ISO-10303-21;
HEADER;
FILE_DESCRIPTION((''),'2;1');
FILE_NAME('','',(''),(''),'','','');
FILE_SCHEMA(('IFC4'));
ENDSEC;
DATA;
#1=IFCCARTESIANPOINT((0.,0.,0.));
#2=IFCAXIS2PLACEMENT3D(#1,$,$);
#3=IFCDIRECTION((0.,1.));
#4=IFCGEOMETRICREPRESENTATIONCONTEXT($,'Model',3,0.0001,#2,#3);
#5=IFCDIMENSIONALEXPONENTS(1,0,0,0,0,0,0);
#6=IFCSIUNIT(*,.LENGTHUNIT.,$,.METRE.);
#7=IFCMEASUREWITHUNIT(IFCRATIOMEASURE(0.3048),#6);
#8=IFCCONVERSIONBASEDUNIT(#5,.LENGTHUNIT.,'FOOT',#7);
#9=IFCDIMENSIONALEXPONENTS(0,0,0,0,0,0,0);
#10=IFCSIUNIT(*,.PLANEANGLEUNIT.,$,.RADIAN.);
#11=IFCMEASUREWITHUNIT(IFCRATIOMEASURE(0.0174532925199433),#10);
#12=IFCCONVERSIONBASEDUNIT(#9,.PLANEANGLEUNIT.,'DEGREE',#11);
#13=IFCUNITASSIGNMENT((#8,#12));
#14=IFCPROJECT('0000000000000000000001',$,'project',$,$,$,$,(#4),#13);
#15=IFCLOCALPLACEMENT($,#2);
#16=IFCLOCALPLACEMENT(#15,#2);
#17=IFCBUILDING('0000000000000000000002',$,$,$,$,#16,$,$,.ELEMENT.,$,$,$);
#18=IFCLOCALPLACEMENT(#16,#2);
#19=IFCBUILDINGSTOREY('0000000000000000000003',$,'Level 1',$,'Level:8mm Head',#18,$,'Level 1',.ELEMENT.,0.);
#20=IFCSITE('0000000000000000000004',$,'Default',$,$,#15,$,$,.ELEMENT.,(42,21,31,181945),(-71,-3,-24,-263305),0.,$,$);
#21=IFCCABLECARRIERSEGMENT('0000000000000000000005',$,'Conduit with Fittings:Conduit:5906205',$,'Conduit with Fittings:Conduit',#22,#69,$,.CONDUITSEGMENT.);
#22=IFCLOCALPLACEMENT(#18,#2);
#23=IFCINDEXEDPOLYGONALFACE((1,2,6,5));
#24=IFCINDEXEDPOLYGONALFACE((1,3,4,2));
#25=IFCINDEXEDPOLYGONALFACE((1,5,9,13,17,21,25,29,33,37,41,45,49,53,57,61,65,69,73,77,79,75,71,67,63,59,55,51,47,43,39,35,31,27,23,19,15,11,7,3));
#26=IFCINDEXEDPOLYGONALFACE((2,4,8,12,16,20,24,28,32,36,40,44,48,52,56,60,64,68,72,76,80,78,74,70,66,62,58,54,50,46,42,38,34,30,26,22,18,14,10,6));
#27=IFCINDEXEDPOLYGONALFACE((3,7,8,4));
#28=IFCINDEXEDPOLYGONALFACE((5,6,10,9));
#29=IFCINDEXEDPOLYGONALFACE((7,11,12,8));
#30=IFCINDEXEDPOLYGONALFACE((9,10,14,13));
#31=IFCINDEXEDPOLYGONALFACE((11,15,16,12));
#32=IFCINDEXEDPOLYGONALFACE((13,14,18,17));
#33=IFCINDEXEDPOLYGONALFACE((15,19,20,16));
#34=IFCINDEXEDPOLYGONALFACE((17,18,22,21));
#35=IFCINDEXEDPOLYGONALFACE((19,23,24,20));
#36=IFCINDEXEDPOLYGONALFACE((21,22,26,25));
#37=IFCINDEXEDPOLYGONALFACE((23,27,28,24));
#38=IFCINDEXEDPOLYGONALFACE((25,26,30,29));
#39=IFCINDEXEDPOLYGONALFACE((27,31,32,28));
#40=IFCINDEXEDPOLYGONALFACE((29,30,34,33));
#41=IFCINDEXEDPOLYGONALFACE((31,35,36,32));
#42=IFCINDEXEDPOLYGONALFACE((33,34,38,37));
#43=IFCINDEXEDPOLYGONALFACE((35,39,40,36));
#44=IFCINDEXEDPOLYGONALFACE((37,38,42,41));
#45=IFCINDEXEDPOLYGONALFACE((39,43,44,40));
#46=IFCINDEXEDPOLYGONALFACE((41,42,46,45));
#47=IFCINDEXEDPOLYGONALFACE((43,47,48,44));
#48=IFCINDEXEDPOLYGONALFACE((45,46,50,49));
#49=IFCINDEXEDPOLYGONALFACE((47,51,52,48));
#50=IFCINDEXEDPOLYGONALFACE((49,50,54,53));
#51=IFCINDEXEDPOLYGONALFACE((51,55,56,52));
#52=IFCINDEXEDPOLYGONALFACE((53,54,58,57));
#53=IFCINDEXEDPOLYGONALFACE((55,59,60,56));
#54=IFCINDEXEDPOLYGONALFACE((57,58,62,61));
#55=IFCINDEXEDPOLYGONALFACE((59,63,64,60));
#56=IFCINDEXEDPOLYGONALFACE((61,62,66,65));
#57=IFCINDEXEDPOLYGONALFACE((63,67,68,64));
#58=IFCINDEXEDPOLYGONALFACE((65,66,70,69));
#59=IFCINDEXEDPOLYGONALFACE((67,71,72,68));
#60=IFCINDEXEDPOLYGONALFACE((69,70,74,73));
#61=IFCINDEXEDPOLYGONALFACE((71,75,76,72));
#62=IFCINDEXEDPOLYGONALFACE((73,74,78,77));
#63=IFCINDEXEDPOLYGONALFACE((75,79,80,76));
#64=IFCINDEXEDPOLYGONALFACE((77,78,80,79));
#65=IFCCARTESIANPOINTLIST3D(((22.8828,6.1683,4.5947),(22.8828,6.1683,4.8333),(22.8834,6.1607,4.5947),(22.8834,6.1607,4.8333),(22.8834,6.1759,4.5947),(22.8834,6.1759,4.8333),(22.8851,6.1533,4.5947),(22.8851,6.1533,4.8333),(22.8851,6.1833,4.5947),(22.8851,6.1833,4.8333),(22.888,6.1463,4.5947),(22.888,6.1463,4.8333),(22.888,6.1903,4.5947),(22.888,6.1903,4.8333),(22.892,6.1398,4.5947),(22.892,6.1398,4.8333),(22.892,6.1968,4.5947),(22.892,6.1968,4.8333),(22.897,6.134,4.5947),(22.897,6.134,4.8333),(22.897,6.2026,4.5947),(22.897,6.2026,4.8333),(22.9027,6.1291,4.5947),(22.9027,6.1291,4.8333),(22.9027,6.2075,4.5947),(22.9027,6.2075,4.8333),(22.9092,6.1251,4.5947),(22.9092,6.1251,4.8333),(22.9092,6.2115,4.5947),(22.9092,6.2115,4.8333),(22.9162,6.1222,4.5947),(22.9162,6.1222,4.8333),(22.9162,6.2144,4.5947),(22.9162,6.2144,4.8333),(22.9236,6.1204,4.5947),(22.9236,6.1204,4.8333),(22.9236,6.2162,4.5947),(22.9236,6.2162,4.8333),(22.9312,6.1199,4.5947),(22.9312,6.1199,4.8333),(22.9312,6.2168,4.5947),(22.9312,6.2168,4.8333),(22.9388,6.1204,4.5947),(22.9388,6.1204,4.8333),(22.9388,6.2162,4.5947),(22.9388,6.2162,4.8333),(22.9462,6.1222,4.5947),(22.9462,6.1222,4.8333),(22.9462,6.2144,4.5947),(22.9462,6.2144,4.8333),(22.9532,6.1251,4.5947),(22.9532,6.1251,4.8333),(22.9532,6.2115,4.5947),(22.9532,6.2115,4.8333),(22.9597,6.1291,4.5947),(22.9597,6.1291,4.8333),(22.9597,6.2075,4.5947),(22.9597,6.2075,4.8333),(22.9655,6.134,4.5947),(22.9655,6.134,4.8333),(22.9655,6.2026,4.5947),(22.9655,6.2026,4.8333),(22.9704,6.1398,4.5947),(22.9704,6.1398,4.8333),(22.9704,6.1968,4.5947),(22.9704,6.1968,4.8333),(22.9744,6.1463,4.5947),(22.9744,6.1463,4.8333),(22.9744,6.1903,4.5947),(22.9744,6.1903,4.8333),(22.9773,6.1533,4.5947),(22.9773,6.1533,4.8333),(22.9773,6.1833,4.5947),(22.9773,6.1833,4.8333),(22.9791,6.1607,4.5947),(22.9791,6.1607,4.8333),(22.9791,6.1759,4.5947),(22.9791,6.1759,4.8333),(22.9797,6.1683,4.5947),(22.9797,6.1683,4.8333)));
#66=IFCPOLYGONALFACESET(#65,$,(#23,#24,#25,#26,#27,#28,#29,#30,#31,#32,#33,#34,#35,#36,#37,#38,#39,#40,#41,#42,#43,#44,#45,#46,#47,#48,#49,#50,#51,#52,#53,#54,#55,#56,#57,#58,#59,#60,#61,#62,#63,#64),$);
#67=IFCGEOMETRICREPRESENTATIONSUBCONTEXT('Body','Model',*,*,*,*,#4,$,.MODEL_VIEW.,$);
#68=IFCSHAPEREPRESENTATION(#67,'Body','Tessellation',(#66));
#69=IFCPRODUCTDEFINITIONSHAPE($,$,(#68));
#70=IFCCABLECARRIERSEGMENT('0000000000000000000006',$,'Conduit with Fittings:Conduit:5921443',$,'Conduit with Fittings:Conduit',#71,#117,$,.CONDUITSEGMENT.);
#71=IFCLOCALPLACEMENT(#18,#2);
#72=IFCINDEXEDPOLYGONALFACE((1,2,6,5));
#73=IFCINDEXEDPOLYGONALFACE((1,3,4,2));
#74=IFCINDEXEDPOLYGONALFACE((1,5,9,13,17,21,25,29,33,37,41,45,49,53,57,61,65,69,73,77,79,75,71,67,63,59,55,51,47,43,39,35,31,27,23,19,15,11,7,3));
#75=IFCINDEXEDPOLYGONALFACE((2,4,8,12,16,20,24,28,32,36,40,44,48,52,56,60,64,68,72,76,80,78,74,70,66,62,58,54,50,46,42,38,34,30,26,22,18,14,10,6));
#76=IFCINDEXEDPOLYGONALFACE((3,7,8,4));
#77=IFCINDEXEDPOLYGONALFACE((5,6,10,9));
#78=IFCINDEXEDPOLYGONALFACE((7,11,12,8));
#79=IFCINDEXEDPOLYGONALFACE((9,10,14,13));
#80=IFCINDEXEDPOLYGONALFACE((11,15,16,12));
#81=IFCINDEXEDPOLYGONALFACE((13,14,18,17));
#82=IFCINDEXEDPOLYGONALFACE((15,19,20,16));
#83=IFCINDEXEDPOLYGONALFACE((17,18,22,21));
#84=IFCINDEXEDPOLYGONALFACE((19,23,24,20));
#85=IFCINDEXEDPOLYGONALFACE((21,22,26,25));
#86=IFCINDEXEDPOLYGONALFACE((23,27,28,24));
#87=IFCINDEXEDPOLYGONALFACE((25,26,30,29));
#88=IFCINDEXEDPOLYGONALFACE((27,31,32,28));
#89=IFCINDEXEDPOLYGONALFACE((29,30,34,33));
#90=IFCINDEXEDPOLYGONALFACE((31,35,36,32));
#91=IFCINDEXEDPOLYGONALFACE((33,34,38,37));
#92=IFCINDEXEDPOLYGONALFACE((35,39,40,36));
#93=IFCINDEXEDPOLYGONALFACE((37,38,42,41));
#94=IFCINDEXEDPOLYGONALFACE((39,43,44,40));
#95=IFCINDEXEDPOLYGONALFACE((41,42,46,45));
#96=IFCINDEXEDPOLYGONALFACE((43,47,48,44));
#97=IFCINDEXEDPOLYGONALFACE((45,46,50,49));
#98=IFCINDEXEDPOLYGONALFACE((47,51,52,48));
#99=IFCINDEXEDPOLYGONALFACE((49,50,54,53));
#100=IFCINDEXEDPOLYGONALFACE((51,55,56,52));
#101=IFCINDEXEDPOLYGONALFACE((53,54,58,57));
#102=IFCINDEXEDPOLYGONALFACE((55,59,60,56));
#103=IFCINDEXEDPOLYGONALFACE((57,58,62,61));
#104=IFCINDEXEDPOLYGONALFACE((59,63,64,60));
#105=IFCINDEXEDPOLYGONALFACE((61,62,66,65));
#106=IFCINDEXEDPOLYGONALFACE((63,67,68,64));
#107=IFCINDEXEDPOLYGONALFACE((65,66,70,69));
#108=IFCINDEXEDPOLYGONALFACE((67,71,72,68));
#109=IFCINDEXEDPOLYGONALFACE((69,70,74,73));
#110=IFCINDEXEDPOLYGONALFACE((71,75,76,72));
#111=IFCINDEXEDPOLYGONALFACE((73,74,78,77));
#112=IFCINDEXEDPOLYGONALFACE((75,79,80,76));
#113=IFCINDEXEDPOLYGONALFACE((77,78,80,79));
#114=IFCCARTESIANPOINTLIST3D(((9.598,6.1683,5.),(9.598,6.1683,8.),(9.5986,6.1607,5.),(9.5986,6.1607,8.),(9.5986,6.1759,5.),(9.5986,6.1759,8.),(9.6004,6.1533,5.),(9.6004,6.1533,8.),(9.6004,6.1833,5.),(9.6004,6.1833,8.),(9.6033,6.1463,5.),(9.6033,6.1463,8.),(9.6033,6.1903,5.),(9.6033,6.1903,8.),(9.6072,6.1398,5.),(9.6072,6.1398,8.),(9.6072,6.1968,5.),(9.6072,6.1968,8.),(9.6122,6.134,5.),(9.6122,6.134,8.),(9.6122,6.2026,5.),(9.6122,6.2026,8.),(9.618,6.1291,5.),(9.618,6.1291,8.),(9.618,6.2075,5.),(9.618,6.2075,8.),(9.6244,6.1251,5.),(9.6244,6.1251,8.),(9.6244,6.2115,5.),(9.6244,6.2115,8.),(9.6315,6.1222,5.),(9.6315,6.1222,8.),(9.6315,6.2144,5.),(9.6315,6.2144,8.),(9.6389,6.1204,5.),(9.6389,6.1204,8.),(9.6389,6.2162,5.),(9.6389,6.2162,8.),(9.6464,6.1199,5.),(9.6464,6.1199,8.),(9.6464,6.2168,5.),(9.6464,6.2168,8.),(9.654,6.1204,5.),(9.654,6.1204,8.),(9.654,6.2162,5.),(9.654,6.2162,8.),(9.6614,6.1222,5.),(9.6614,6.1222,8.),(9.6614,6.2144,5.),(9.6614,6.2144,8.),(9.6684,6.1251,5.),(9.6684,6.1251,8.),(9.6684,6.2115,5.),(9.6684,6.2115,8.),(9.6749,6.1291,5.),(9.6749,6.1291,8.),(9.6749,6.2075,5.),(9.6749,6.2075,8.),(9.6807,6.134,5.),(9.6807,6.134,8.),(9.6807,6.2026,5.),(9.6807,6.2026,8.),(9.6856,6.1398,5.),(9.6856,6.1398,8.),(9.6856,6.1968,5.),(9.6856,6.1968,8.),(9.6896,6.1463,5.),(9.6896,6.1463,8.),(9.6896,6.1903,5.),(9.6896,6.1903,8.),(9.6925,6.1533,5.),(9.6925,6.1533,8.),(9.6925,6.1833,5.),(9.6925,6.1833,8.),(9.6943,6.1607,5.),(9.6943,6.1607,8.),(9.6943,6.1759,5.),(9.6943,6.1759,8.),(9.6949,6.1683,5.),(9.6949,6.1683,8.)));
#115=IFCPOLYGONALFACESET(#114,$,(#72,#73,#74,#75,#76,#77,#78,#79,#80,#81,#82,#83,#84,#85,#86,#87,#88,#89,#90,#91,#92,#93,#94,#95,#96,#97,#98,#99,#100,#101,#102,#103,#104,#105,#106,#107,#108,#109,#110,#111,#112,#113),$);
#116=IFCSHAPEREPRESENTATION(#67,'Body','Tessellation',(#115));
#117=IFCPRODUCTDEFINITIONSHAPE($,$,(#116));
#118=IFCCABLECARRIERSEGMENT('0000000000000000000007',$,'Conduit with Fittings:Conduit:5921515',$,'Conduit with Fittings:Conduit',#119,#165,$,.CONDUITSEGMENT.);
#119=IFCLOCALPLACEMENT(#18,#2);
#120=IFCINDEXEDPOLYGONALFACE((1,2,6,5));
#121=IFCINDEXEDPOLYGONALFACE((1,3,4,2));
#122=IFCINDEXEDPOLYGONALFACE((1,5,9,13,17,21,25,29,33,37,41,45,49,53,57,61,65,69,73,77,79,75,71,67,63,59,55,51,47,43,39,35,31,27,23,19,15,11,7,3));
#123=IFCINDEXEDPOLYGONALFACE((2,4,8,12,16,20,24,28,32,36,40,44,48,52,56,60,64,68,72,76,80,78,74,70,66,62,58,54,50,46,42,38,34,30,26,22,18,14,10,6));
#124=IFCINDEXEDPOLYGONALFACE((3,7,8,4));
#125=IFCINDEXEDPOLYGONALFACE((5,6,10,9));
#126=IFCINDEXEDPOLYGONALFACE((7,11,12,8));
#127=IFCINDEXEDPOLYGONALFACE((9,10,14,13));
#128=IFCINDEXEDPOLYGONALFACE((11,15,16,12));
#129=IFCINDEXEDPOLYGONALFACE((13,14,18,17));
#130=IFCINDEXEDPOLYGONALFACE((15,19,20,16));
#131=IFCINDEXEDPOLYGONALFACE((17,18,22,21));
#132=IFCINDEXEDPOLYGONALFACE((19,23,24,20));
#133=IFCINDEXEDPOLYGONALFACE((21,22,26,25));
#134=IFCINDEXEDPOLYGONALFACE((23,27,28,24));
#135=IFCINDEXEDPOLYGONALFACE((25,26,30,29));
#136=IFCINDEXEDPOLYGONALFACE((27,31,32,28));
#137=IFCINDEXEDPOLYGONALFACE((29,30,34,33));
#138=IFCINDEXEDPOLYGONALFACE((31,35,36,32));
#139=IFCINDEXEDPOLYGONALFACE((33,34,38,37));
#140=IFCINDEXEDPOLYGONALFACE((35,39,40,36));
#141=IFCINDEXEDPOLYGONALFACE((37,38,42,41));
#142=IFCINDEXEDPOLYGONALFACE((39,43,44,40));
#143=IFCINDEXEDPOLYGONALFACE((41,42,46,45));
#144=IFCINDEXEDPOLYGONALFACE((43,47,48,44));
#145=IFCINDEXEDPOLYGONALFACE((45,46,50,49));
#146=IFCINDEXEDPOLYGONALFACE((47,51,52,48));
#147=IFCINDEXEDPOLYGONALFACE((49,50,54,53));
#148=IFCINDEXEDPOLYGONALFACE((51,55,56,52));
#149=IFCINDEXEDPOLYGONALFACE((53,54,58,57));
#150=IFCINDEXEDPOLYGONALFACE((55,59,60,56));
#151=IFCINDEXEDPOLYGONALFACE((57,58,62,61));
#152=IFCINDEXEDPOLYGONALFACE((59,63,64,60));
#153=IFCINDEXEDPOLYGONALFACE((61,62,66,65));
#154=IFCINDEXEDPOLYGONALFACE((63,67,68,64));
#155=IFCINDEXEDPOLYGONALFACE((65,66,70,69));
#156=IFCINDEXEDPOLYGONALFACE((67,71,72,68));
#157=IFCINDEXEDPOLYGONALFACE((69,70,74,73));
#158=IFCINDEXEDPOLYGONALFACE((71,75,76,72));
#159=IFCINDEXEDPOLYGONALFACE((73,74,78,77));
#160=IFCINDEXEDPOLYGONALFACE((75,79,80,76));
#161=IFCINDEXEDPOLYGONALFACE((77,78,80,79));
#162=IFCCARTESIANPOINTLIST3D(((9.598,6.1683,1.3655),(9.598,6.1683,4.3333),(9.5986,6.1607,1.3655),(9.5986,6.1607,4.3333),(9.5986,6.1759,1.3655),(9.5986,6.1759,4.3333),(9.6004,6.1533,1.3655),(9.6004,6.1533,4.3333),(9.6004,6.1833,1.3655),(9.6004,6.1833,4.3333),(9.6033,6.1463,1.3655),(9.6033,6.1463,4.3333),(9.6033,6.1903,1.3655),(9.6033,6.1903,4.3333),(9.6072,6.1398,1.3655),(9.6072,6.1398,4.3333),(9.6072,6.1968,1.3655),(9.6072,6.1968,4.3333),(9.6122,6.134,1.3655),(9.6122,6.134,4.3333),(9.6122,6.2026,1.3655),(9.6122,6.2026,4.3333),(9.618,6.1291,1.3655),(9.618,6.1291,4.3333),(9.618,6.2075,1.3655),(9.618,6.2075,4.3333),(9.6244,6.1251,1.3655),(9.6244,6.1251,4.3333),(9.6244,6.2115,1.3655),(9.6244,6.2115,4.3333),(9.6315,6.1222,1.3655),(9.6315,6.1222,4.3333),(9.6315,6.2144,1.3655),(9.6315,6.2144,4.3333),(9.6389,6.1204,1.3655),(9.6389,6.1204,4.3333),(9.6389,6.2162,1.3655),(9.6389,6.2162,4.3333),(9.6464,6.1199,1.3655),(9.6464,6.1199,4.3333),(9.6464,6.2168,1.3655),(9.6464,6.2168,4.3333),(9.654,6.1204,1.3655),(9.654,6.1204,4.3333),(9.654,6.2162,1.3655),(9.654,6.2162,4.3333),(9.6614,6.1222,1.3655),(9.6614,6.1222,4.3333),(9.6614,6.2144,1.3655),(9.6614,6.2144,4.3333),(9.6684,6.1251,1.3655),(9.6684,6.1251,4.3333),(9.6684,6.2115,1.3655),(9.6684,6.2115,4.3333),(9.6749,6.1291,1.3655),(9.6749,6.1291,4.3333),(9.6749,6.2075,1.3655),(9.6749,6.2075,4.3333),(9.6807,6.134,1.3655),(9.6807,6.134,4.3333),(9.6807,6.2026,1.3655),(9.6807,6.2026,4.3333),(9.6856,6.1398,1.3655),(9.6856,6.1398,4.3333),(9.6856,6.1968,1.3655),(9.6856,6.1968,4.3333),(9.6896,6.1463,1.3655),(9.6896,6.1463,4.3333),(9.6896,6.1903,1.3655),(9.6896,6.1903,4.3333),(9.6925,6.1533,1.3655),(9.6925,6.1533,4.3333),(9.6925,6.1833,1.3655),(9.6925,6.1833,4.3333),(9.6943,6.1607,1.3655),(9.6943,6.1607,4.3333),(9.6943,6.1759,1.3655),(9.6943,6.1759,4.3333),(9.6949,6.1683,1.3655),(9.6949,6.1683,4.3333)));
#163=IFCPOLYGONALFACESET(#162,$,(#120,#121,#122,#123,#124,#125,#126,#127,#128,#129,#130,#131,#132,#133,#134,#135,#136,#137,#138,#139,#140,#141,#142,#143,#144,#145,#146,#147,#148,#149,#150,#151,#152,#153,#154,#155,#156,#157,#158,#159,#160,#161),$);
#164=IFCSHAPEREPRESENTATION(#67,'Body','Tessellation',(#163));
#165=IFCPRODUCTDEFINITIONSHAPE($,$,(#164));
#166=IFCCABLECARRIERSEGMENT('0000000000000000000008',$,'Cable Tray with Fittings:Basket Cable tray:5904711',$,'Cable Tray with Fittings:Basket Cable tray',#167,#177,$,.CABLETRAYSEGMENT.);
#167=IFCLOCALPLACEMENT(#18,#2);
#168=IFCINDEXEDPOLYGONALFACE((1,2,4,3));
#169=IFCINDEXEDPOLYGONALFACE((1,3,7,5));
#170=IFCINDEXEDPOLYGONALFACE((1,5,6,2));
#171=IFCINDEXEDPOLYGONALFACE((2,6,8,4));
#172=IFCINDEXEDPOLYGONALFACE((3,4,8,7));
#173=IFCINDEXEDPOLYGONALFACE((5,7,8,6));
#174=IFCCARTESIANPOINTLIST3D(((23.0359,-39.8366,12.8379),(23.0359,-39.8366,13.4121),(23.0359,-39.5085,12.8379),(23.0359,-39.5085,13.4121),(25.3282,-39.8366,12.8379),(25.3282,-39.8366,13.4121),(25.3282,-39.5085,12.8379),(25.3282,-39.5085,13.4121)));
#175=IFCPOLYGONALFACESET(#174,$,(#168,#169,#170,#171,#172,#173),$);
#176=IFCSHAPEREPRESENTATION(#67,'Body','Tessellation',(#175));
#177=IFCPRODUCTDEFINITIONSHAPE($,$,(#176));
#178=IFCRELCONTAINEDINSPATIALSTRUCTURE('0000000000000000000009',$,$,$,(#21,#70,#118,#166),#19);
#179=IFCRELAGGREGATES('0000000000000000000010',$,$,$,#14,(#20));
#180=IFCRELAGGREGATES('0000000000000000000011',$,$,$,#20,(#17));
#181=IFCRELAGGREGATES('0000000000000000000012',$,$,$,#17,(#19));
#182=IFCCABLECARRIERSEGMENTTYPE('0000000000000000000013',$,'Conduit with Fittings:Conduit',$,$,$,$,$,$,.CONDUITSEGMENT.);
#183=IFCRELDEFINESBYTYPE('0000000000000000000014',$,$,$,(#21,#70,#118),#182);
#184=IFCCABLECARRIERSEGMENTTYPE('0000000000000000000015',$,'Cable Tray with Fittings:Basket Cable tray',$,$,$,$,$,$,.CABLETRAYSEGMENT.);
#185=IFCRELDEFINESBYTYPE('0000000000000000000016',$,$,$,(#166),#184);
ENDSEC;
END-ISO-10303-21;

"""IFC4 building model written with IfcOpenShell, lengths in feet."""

from ifc_helpers import new_model, entity, si_unit, converted_unit, direction, frame, origin, place, context, subcontext, project, spatial, indexed_curve, outline, extrude, type_object, element, save


model = new_model("IFC4")

# Units and contexts
model_context = context("Model", 3, precision=0.0001, world=origin(), true_north=direction((0.0, 1.0)))
body_context = subcontext(model_context, "Body", "Model", "MODEL_VIEW")
ifc_project = project(units=[converted_unit("LENGTHUNIT", "FOOT", entity("IfcRatioMeasure", 0.3048), si_unit("LENGTHUNIT", "METRE"), dimensions=[1, 0, 0, 0, 0, 0, 0]), converted_unit("PLANEANGLEUNIT", "DEGREE", entity("IfcRatioMeasure", 0.0174532925199433), si_unit("PLANEANGLEUNIT", "RADIAN"), dimensions=[0, 0, 0, 0, 0, 0, 0])], contexts=[model_context])

# Site, building, storey
site_placement = place(None, origin())
site = spatial("IfcSite", under=ifc_project, at=site_placement, Name="Default", CompositionType="ELEMENT", RefLatitude=(42, 21, 31, 181945), RefLongitude=(-71, -3, -24, -263305), RefElevation=0.0)
building_placement = place(site_placement, origin())
building = spatial("IfcBuilding", under=site, at=building_placement, CompositionType="ELEMENT")
storey_placement = place(building_placement, origin())
storey = spatial("IfcBuildingStorey", under=building, at=storey_placement, Name="Level 1", ObjectType="Level:8mm Head", LongName="Level 1", CompositionType="ELEMENT", Elevation=0.0)

# Cable carrier segments
cable_carrier_segment_type_1 = type_object("IfcCableCarrierSegmentType", Name="Conduit with Fittings:Conduit", PredefinedType="CONDUITSEGMENT")
cable_carrier_segment_1_placement = place(storey_placement, origin())
element("IfcCableCarrierSegment", 1, at=cable_carrier_segment_1_placement, inside=storey, type_object=cable_carrier_segment_type_1, Name="Conduit with Fittings:Conduit:5906205", ObjectType="Conduit with Fittings:Conduit", PredefinedType="CONDUITSEGMENT", context=body_context, shape_type="SweptSolid", body=[
    extrude(outline(indexed_curve([(0.0485, 0.0), (0.0479, 0.0076), (0.0461, 0.015), (0.0432, 0.022), (0.0392, 0.0285), (0.0343, 0.0343), (0.0285, 0.0392), (0.022, 0.0432), (0.015, 0.0461), (0.0076, 0.0479), (0.0, 0.0485), (-0.0076, 0.0479), (-0.015, 0.0461), (-0.022, 0.0432), (-0.0285, 0.0392), (-0.0343, 0.0343), (-0.0392, 0.0285), (-0.0432, 0.022), (-0.0461, 0.015), (-0.0479, 0.0076), (-0.0485, 0.0), (-0.0479, -0.0076), (-0.0461, -0.015), (-0.0432, -0.022), (-0.0392, -0.0285), (-0.0343, -0.0343), (-0.0285, -0.0392), (-0.022, -0.0432), (-0.015, -0.0461), (-0.0076, -0.0479), (0.0, -0.0485), (0.0076, -0.0479), (0.015, -0.0461), (0.022, -0.0432), (0.0285, -0.0392), (0.0343, -0.0343), (0.0392, -0.0285), (0.0432, -0.022), (0.0461, -0.015), (0.0479, -0.0076), (0.0485, 0.0)], self_intersect=False)), frame((22.9312, 6.1683, 4.5947), z_axis=(0.0, 0.0, 1.0), x_axis=(-1.0, 0.0, 0.0)), (0.0, 0.0, 1.0), 0.2387),
])
cable_carrier_segment_2_placement = place(storey_placement, origin())
element("IfcCableCarrierSegment", 2, at=cable_carrier_segment_2_placement, inside=storey, type_object=cable_carrier_segment_type_1, Name="Conduit with Fittings:Conduit:5921443", ObjectType="Conduit with Fittings:Conduit", PredefinedType="CONDUITSEGMENT", context=body_context, shape_type="SweptSolid", body=[
    extrude(outline(indexed_curve([(0.0485, 0.0), (0.0479, 0.0076), (0.0461, 0.015), (0.0432, 0.022), (0.0392, 0.0285), (0.0343, 0.0343), (0.0285, 0.0392), (0.022, 0.0432), (0.015, 0.0461), (0.0076, 0.0479), (0.0, 0.0485), (-0.0076, 0.0479), (-0.015, 0.0461), (-0.022, 0.0432), (-0.0285, 0.0392), (-0.0343, 0.0343), (-0.0392, 0.0285), (-0.0432, 0.022), (-0.0461, 0.015), (-0.0479, 0.0076), (-0.0485, 0.0), (-0.0479, -0.0076), (-0.0461, -0.015), (-0.0432, -0.022), (-0.0392, -0.0285), (-0.0343, -0.0343), (-0.0285, -0.0392), (-0.022, -0.0432), (-0.015, -0.0461), (-0.0076, -0.0479), (0.0, -0.0485), (0.0076, -0.0479), (0.015, -0.0461), (0.022, -0.0432), (0.0285, -0.0392), (0.0343, -0.0343), (0.0392, -0.0285), (0.0432, -0.022), (0.0461, -0.015), (0.0479, -0.0076), (0.0485, 0.0)], self_intersect=False)), frame((9.6464, 6.1683, 5.0)), (0.0, 0.0, 1.0), 3.0),
])
cable_carrier_segment_3_placement = place(storey_placement, origin())
element("IfcCableCarrierSegment", 3, at=cable_carrier_segment_3_placement, inside=storey, type_object=cable_carrier_segment_type_1, Name="Conduit with Fittings:Conduit:5921515", ObjectType="Conduit with Fittings:Conduit", PredefinedType="CONDUITSEGMENT", context=body_context, shape_type="SweptSolid", body=[
    extrude(outline(indexed_curve([(0.0485, 0.0), (0.0479, 0.0076), (0.0461, 0.015), (0.0432, 0.022), (0.0392, 0.0285), (0.0343, 0.0343), (0.0285, 0.0392), (0.022, 0.0432), (0.015, 0.0461), (0.0076, 0.0479), (0.0, 0.0485), (-0.0076, 0.0479), (-0.015, 0.0461), (-0.022, 0.0432), (-0.0285, 0.0392), (-0.0343, 0.0343), (-0.0392, 0.0285), (-0.0432, 0.022), (-0.0461, 0.015), (-0.0479, 0.0076), (-0.0485, 0.0), (-0.0479, -0.0076), (-0.0461, -0.015), (-0.0432, -0.022), (-0.0392, -0.0285), (-0.0343, -0.0343), (-0.0285, -0.0392), (-0.022, -0.0432), (-0.015, -0.0461), (-0.0076, -0.0479), (0.0, -0.0485), (0.0076, -0.0479), (0.015, -0.0461), (0.022, -0.0432), (0.0285, -0.0392), (0.0343, -0.0343), (0.0392, -0.0285), (0.0432, -0.022), (0.0461, -0.015), (0.0479, -0.0076), (0.0485, 0.0)], self_intersect=False)), frame((9.6464, 6.1683, 1.3655)), (0.0, 0.0, 1.0), 2.9678),
])
cable_carrier_segment_type_2 = type_object("IfcCableCarrierSegmentType", Name="Cable Tray with Fittings:Basket Cable tray", PredefinedType="CABLETRAYSEGMENT")
cable_carrier_segment_4_placement = place(storey_placement, origin())
element("IfcCableCarrierSegment", 4, at=cable_carrier_segment_4_placement, inside=storey, type_object=cable_carrier_segment_type_2, Name="Cable Tray with Fittings:Basket Cable tray:5904711", ObjectType="Cable Tray with Fittings:Basket Cable tray", PredefinedType="CABLETRAYSEGMENT", context=body_context, shape_type="SweptSolid", body=[
    extrude(outline(indexed_curve([(-1.1462, -0.164), (1.1462, -0.164), (1.1462, 0.164), (-1.1462, 0.164), (-1.1462, -0.164)], self_intersect=False)), frame((24.1821, -39.6725, 12.8379), z_axis=(0.0, 0.0, 1.0), x_axis=(-1.0, 0.0, 0.0)), (0.0, 0.0, 1.0), 0.5741),
])

save(model, "model.ifc")
